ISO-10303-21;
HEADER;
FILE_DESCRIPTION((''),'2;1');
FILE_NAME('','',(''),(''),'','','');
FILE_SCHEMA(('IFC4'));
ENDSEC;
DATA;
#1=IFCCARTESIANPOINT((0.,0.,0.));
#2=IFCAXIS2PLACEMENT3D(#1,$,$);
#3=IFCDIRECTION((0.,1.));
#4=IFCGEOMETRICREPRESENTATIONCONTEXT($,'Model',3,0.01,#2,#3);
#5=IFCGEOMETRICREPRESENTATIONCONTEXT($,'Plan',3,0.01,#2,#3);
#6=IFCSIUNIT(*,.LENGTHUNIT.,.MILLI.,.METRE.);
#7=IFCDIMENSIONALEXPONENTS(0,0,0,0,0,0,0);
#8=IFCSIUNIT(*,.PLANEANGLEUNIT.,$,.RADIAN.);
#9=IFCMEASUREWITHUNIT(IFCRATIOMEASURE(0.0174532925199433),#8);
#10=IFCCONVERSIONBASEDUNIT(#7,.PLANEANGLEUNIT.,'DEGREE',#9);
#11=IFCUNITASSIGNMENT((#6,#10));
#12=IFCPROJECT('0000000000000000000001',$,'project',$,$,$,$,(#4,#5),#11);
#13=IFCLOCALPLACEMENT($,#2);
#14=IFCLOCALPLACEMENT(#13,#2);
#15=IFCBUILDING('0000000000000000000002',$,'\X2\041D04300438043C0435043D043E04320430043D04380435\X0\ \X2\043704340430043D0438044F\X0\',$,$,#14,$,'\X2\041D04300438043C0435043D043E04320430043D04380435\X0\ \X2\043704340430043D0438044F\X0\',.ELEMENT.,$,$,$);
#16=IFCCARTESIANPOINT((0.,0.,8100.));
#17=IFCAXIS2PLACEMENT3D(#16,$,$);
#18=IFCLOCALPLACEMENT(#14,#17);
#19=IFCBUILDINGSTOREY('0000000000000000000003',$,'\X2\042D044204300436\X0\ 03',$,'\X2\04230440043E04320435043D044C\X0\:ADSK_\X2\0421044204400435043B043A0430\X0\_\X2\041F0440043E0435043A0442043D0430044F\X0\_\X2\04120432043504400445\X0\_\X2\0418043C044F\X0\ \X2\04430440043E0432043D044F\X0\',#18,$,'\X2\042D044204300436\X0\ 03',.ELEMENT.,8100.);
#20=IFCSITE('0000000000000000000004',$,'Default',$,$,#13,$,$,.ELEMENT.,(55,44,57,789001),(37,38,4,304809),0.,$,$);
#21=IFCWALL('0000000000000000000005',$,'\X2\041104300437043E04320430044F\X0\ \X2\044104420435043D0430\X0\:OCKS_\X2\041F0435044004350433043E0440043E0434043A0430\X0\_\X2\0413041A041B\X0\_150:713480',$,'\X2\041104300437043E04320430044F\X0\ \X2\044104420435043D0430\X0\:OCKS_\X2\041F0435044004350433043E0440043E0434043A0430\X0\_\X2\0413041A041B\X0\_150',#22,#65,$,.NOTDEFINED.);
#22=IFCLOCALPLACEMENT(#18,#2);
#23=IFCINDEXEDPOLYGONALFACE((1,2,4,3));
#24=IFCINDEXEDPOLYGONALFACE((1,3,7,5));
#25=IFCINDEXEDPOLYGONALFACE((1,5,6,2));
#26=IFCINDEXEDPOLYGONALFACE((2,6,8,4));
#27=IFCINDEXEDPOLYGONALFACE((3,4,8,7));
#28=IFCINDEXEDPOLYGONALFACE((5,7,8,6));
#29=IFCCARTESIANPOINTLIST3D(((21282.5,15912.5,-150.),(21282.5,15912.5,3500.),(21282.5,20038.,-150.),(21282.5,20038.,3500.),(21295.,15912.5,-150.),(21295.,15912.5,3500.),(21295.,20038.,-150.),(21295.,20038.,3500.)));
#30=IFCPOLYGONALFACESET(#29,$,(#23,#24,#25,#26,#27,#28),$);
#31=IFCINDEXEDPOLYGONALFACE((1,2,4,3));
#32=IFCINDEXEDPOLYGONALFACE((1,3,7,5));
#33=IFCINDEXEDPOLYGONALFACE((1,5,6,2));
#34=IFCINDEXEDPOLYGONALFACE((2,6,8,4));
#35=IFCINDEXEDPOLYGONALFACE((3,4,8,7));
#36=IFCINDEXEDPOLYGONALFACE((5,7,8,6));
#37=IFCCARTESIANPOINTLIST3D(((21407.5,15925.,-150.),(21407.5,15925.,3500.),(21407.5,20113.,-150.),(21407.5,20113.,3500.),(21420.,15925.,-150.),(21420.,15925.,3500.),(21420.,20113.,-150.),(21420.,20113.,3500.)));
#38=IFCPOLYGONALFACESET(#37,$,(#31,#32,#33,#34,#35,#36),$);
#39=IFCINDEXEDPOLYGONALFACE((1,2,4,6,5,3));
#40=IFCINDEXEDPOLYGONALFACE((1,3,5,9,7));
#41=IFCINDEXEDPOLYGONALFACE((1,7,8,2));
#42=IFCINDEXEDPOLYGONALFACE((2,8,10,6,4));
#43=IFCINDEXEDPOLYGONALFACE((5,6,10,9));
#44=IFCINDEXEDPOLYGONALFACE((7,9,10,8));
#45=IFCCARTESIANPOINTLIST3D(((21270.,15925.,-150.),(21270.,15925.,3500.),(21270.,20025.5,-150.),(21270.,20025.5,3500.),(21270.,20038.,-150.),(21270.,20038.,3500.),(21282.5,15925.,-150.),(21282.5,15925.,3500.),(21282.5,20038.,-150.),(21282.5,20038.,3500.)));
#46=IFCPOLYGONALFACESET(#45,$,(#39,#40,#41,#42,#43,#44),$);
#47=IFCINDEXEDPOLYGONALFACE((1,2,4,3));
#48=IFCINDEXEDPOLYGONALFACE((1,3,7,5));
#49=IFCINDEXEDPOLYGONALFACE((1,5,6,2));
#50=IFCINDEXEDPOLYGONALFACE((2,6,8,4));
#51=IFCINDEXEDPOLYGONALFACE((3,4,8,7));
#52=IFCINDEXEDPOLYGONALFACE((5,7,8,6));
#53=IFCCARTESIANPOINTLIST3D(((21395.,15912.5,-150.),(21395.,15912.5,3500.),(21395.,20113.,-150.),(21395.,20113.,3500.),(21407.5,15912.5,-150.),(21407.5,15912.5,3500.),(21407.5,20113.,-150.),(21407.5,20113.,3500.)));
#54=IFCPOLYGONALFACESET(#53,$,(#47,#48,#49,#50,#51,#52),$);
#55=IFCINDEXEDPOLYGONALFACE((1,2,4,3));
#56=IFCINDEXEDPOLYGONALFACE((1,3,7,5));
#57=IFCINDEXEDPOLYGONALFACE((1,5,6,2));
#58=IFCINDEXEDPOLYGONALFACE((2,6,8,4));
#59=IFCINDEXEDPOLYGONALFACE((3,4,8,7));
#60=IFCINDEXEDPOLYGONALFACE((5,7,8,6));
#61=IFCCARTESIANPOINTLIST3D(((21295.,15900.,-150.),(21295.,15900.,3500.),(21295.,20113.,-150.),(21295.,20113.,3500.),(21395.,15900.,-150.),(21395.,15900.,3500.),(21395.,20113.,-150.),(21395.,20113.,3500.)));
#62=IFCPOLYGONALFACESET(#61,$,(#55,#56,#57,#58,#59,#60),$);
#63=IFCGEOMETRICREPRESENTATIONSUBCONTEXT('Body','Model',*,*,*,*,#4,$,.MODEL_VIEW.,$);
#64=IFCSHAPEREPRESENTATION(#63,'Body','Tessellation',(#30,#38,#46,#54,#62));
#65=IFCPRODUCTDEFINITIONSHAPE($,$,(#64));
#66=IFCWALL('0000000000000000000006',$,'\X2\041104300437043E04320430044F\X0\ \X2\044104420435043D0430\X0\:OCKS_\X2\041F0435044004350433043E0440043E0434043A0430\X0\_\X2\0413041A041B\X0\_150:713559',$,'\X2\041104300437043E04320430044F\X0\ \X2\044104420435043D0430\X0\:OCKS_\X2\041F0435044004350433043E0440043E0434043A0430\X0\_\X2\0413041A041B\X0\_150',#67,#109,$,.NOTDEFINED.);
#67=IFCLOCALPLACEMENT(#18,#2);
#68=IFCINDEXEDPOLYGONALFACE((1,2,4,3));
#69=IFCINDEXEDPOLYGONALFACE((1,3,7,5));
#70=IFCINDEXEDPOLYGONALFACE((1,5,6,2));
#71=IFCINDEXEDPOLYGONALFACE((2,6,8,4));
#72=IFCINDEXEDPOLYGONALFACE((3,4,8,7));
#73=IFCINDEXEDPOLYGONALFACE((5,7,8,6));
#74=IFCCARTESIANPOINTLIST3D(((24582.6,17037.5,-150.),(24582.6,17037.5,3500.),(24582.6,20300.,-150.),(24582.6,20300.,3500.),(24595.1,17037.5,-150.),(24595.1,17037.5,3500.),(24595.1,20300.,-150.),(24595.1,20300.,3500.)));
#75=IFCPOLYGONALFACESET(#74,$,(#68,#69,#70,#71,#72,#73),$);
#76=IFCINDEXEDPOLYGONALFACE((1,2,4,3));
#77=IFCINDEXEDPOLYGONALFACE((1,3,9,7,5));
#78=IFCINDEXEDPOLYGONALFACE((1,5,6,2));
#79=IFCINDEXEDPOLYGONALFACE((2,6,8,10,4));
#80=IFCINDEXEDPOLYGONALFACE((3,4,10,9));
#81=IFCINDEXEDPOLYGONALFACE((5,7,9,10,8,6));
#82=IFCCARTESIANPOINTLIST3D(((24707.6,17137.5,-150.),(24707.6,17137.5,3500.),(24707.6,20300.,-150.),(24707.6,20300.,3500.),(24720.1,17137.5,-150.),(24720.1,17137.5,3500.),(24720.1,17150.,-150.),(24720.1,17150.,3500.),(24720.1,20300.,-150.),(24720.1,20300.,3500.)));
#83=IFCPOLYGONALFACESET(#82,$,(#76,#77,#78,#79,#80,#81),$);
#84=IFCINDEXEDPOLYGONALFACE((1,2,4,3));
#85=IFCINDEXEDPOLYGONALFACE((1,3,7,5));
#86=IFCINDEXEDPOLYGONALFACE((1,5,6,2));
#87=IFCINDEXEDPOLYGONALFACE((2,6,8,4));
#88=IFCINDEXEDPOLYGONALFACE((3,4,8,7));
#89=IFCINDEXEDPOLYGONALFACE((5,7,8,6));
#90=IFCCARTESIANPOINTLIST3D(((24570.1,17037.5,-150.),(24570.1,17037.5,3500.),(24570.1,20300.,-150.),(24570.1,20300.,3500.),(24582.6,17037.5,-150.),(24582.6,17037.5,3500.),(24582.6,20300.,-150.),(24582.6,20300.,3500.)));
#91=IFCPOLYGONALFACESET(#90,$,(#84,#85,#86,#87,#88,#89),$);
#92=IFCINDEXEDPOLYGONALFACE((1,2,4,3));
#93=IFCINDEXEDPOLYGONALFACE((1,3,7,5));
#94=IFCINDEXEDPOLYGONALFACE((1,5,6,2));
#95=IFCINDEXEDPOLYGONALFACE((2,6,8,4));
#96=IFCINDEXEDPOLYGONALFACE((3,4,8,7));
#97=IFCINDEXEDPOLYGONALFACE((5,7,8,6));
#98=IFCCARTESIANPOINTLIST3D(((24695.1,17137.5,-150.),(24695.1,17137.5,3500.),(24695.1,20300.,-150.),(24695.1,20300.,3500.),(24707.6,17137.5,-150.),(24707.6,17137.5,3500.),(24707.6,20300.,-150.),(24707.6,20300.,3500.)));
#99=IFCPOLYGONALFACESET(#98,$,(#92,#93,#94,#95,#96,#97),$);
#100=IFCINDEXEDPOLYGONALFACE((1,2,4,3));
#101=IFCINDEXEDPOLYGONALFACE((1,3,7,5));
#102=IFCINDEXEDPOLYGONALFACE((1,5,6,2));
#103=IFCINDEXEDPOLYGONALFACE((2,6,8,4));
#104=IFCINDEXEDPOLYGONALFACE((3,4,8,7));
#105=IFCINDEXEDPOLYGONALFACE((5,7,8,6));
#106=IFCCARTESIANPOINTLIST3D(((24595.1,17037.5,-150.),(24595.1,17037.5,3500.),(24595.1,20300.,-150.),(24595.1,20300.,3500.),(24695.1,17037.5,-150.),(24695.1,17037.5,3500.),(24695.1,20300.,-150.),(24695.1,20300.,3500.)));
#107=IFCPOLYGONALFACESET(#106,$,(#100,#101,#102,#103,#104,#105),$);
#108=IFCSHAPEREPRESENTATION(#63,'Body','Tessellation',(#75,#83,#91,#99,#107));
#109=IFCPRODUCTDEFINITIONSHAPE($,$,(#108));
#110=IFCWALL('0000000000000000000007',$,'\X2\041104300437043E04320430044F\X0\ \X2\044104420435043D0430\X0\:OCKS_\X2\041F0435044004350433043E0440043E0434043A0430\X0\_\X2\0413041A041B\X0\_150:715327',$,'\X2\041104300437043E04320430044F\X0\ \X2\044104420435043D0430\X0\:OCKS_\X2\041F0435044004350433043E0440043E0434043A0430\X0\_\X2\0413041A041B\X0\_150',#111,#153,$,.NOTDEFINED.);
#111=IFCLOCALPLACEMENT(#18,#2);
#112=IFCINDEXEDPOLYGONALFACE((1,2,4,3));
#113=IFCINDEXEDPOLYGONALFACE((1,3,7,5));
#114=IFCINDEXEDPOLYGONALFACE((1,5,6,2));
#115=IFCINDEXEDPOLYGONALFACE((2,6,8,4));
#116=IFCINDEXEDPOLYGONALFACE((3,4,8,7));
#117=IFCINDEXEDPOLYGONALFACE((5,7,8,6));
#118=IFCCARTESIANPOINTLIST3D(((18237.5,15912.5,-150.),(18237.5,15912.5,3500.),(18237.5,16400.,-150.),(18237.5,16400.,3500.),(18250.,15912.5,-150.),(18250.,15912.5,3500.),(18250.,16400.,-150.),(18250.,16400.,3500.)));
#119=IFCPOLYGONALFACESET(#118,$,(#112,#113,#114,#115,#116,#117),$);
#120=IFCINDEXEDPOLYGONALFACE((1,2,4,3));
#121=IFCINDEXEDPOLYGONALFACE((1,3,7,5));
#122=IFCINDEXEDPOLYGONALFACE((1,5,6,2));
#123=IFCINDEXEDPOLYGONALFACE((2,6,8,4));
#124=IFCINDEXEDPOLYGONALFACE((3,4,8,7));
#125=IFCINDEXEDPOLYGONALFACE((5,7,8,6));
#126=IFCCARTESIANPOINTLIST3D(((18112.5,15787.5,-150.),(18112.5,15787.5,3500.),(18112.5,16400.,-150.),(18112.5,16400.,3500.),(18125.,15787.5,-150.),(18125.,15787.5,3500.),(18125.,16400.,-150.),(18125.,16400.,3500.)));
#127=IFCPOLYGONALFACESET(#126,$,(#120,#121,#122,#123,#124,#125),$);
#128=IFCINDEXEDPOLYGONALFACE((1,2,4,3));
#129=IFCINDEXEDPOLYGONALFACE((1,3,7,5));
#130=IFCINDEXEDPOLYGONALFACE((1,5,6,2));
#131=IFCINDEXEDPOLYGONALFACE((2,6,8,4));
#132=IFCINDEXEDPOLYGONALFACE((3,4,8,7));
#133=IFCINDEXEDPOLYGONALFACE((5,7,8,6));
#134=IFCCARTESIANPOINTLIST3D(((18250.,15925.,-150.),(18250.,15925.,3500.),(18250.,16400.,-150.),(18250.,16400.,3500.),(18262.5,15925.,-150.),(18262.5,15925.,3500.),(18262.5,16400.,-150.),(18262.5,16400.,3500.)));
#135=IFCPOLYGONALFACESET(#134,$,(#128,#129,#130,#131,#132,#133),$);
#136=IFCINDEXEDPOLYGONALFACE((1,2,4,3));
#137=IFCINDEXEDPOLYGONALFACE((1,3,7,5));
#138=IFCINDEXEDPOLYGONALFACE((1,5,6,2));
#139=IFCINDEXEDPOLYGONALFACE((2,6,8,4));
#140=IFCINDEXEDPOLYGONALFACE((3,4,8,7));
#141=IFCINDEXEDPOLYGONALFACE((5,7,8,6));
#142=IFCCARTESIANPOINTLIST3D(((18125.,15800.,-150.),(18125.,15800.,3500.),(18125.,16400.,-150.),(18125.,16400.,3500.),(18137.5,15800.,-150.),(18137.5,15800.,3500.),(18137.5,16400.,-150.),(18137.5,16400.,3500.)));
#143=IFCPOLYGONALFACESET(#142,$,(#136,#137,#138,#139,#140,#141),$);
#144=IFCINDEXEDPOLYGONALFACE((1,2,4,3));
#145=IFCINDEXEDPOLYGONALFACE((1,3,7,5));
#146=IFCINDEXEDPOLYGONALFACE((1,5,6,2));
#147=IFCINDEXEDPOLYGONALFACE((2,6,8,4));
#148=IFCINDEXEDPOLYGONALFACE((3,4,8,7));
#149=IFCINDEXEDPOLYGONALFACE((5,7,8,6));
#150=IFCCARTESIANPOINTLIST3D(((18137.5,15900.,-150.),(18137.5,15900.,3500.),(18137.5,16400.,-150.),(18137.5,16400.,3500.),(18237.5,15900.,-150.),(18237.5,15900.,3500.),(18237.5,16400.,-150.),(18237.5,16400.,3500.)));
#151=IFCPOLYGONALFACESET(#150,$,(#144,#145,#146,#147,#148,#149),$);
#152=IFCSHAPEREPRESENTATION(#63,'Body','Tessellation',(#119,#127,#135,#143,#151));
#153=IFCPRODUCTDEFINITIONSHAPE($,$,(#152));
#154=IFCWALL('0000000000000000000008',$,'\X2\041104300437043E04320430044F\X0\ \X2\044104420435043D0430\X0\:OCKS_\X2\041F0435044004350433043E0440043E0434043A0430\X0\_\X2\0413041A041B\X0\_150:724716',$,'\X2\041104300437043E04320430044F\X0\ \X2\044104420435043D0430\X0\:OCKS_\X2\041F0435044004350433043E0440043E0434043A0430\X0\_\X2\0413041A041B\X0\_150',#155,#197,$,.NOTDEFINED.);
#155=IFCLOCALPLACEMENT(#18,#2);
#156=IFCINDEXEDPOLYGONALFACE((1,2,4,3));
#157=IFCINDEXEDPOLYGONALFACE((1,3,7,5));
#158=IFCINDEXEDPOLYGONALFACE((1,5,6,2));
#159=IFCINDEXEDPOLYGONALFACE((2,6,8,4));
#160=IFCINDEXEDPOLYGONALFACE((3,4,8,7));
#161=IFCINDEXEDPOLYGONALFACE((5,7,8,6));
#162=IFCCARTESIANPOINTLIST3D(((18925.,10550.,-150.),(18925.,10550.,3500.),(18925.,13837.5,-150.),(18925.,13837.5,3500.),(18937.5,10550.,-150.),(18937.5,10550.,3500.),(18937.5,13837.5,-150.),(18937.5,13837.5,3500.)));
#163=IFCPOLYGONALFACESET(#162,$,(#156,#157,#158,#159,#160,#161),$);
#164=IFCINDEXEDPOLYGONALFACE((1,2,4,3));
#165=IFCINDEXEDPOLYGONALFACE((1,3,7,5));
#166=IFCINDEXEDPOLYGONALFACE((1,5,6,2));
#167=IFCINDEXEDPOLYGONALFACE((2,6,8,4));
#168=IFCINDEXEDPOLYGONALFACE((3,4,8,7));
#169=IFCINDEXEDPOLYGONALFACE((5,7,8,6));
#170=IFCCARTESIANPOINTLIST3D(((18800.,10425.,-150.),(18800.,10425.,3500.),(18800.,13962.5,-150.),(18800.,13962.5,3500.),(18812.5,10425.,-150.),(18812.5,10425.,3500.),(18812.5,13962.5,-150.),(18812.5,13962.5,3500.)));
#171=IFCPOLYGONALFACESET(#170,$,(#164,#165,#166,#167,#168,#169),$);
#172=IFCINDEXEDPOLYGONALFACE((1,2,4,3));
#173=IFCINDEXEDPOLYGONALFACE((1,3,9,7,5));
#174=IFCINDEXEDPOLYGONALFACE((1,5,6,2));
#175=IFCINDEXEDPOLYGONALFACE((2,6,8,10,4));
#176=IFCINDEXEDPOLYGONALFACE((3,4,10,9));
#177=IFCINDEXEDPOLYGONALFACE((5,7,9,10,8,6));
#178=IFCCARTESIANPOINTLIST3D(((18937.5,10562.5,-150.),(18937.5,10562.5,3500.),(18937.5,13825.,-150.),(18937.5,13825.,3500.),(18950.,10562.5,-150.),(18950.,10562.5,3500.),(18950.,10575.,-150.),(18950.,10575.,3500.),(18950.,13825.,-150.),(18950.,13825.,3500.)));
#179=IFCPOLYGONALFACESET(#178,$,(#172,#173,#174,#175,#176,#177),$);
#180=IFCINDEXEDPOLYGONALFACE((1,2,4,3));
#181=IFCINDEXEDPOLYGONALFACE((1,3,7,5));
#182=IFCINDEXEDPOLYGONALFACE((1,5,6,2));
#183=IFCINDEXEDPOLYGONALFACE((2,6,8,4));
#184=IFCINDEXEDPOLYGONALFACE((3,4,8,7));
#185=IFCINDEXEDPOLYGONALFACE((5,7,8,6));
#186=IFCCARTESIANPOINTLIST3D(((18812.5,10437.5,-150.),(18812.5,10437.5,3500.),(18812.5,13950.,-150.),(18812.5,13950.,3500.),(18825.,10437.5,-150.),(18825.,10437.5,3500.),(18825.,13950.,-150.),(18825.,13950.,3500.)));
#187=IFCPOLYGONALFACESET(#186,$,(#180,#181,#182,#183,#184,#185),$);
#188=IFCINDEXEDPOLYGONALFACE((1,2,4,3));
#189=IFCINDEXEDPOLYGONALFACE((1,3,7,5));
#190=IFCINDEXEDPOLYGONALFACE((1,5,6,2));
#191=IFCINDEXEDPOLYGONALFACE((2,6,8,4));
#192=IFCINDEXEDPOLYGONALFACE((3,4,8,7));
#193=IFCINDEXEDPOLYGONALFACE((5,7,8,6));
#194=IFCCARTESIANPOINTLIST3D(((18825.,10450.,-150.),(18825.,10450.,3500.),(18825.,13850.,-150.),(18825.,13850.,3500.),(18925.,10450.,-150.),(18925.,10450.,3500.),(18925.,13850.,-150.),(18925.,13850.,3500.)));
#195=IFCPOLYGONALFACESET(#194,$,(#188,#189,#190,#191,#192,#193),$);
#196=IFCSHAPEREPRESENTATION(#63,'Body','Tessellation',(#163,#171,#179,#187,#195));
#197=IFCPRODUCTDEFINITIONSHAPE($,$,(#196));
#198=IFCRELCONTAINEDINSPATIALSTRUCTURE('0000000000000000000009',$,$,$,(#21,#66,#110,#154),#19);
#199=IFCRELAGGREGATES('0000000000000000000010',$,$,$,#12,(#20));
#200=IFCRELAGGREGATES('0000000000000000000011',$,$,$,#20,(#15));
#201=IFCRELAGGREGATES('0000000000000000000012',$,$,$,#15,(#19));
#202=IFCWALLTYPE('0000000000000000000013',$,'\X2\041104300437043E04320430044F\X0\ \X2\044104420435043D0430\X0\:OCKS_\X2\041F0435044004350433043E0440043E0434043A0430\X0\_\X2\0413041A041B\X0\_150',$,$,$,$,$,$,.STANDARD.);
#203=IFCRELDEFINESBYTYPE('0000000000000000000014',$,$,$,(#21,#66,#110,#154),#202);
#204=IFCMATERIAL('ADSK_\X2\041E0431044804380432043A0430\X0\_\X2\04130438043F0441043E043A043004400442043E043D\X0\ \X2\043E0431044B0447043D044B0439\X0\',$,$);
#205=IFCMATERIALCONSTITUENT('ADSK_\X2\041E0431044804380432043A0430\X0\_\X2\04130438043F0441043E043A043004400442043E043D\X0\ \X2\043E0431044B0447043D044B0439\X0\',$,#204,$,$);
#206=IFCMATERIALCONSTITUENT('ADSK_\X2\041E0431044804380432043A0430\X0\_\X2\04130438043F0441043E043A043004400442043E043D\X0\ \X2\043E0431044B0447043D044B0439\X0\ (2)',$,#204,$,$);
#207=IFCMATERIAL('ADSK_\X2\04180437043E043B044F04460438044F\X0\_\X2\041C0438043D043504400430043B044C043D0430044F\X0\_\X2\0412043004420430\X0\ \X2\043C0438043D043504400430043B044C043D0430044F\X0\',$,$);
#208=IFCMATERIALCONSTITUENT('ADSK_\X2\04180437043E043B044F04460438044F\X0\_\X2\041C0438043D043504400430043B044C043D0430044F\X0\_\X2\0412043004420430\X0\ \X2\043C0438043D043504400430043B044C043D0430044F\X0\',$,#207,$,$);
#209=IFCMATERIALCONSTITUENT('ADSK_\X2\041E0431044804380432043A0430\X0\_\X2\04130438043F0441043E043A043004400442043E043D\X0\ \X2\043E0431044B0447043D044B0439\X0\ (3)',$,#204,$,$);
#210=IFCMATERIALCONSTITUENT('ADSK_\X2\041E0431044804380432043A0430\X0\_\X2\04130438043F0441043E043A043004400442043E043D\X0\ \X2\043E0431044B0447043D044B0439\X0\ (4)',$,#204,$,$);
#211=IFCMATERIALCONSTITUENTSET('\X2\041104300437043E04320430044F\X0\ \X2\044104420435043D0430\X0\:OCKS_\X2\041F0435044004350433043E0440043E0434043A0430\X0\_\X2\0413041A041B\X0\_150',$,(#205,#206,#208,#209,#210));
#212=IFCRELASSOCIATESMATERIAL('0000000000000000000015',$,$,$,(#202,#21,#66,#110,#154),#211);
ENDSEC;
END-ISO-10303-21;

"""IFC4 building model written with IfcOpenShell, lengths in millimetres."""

from ifc_helpers import new_model, entity, si_unit, converted_unit, direction, frame, origin, place, context, subcontext, project, spatial, indexed_curve, outline, extrude, material, constituent, constituent_set, type_object, element, save


model = new_model("IFC4")

# Units and contexts
model_context = context("Model", 3, precision=0.01, world=origin(), true_north=direction((0.0, 1.0)))
plan_context = context("Plan", 3, precision=0.01, world=origin(), true_north=direction((0.0, 1.0)))
body_context = subcontext(model_context, "Body", "Model", "MODEL_VIEW")
ifc_project = project(units=[si_unit("LENGTHUNIT", "METRE", prefix="MILLI"), converted_unit("PLANEANGLEUNIT", "DEGREE", entity("IfcRatioMeasure", 0.0174532925199433), si_unit("PLANEANGLEUNIT", "RADIAN"), dimensions=[0, 0, 0, 0, 0, 0, 0])], contexts=[model_context, plan_context])

# Site, building, storey
site_placement = place(None, frame((0.0, 0.0, 0.0)))
site = spatial("IfcSite", under=ifc_project, at=site_placement, Name="Default", CompositionType="ELEMENT", RefLatitude=(55, 44, 57, 789001), RefLongitude=(37, 38, 4, 304809), RefElevation=0.0)
building_placement = place(site_placement, origin())
building = spatial("IfcBuilding", under=site, at=building_placement, Name="Наименование здания", LongName="Наименование здания", CompositionType="ELEMENT")
storey_placement = place(building_placement, frame((0.0, 0.0, 8100.0)))
storey = spatial("IfcBuildingStorey", under=building, at=storey_placement, Name="Этаж 03", ObjectType="Уровень:ADSK_Стрелка_Проектная_Вверх_Имя уровня", LongName="Этаж 03", CompositionType="ELEMENT", Elevation=8100.0)

# Walls
ifc_material_1 = material(Name="ADSK_Обшивка_Гипсокартон обычный")
ifc_constituent_1 = constituent(ifc_material_1, Name="ADSK_Обшивка_Гипсокартон обычный")
ifc_constituent_2 = constituent(ifc_material_1, Name="ADSK_Обшивка_Гипсокартон обычный (2)")
ifc_material_2 = material(Name="ADSK_Изоляция_Минеральная_Вата минеральная")
ifc_constituent_3 = constituent(ifc_material_2, Name="ADSK_Изоляция_Минеральная_Вата минеральная")
ifc_constituent_4 = constituent(ifc_material_1, Name="ADSK_Обшивка_Гипсокартон обычный (3)")
ifc_constituent_5 = constituent(ifc_material_1, Name="ADSK_Обшивка_Гипсокартон обычный (4)")
ifc_constituent_set_1 = constituent_set(constituents=[ifc_constituent_1, ifc_constituent_2, ifc_constituent_3, ifc_constituent_4, ifc_constituent_5], Name="Базовая стена:OCKS_Перегородка_ГКЛ_150")
wall_type_1 = type_object("IfcWallType", Name="Базовая стена:OCKS_Перегородка_ГКЛ_150", PredefinedType="STANDARD", material=ifc_constituent_set_1)
wall_1_placement = place(storey_placement, frame((21345.0, 15925.0, -150.0), z_axis=(0.0, 0.0, 1.0), x_axis=(0.0, 1.0, 0.0)))
element("IfcWall", 1, at=wall_1_placement, inside=storey, type_object=wall_type_1, material=ifc_constituent_set_1, Name="Базовая стена:OCKS_Перегородка_ГКЛ_150:713480", ObjectType="Базовая стена:OCKS_Перегородка_ГКЛ_150", PredefinedType="NOTDEFINED", context=body_context, shape_type="SweptSolid", body=[
    extrude(outline(indexed_curve([(-2062.8, -6.2), (2062.8, -6.2), (2062.8, 6.2), (-2062.8, 6.2), (-2062.8, -6.2)], self_intersect=False)), frame((2050.3, 56.2, 0.0)), (0.0, 0.0, 1.0), 3650.0),
    extrude(outline(indexed_curve([(-6.3, -2094.0), (6.2, -2094.0), (6.3, 2094.0), (-6.2, 2094.0), (-6.3, -2094.0)], self_intersect=False)), frame((2094.0, -68.7, 0.0), z_axis=(0.0, 0.0, 1.0), x_axis=(0.0, 1.0, 0.0)), (0.0, 0.0, 1.0), 3650.0),
    extrude(outline(indexed_curve([(-1635.2, -5.0), (2465.3, -5.0), (2465.3, 7.5), (-1647.7, 7.5), (-1647.7, -5.0), (-1635.2, -5.0)], self_intersect=False)), frame((2465.3, 70.0, 0.0), z_axis=(0.0, 0.0, 1.0), x_axis=(-1.0, 0.0, 0.0)), (0.0, 0.0, 1.0), 3650.0),
    extrude(outline(indexed_curve([(-2100.3, -6.2), (2100.3, -6.2), (2100.3, 6.2), (-2100.3, 6.2), (-2100.3, -6.2)], self_intersect=False)), frame((2087.8, -56.3, 0.0)), (0.0, 0.0, 1.0), 3650.0),
    extrude(outline(indexed_curve([(-2106.5, -50.0), (2106.5, -50.0), (2106.5, 50.0), (-2106.5, 50.0), (-2106.5, -50.0)], self_intersect=False)), frame((2081.5, 0.0, 0.0)), (0.0, 0.0, 1.0), 3650.0),
])
wall_2_placement = place(storey_placement, frame((24645.1, 20300.0, -150.0), z_axis=(0.0, 0.0, 1.0), x_axis=(0.0, -1.0, 0.0)))
element("IfcWall", 2, at=wall_2_placement, inside=storey, type_object=wall_type_1, material=ifc_constituent_set_1, Name="Базовая стена:OCKS_Перегородка_ГКЛ_150:713559", ObjectType="Базовая стена:OCKS_Перегородка_ГКЛ_150", PredefinedType="NOTDEFINED", context=body_context, shape_type="SweptSolid", body=[
    extrude(outline(indexed_curve([(-1631.3, -6.2), (1631.3, -6.2), (1631.3, 6.3), (-1631.3, 6.3), (-1631.3, -6.2)], self_intersect=False)), frame((1631.3, -56.3, 0.0)), (0.0, 0.0, 1.0), 3650.0),
    extrude(outline(indexed_curve([(-1255.0, -5.0), (1895.0, -5.0), (1895.0, 7.5), (-1267.5, 7.5), (-1267.5, -5.0), (-1255.0, -5.0)], self_intersect=False)), frame((1895.0, 70.0, 0.0), z_axis=(0.0, 0.0, 1.0), x_axis=(-1.0, 0.0, 0.0)), (0.0, 0.0, 1.0), 3650.0),
    extrude(outline(indexed_curve([(-6.3, -1631.3), (6.2, -1631.3), (6.3, 1631.3), (-6.2, 1631.3), (-6.3, -1631.3)], self_intersect=False)), frame((1631.3, -68.7, 0.0), z_axis=(0.0, 0.0, 1.0), x_axis=(0.0, 1.0, 0.0)), (0.0, 0.0, 1.0), 3650.0),
    extrude(outline(indexed_curve([(-1581.3, -6.2), (1581.3, -6.2), (1581.3, 6.3), (-1581.3, 6.3), (-1581.3, -6.2)], self_intersect=False)), frame((1581.3, 56.2, 0.0)), (0.0, 0.0, 1.0), 3650.0),
    extrude(outline(indexed_curve([(-1631.3, -50.0), (1631.3, -50.0), (1631.3, 50.0), (-1631.3, 50.0), (-1631.3, -50.0)], self_intersect=False)), frame((1631.3, 0.0, 0.0)), (0.0, 0.0, 1.0), 3650.0),
])

# Wall
wall_3_placement = place(storey_placement, frame((18187.5, 15925.0, -150.0), z_axis=(0.0, 0.0, 1.0), x_axis=(0.0, 1.0, 0.0)))
element("IfcWall", 3, at=wall_3_placement, inside=storey, type_object=wall_type_1, material=ifc_constituent_set_1, Name="Базовая стена:OCKS_Перегородка_ГКЛ_150:715327", ObjectType="Базовая стена:OCKS_Перегородка_ГКЛ_150", PredefinedType="NOTDEFINED", context=body_context, shape_type="SweptSolid", body=[
    extrude(outline(indexed_curve([(-243.8, -6.3), (243.8, -6.3), (243.8, 6.3), (-243.8, 6.3), (-243.8, -6.3)], self_intersect=False)), frame((231.3, -56.3, 0.0)), (0.0, 0.0, 1.0), 3650.0),
    extrude(outline(indexed_curve([(-6.3, -306.3), (6.2, -306.3), (6.2, 306.3), (-6.3, 306.3), (-6.3, -306.3)], self_intersect=False)), frame((168.8, 68.7, 0.0), z_axis=(0.0, 0.0, 1.0), x_axis=(0.0, -1.0, 0.0)), (0.0, 0.0, 1.0), 3650.0),
    extrude(outline(indexed_curve([(-6.3, -237.5), (6.2, -237.5), (6.2, 237.5), (-6.3, 237.5), (-6.3, -237.5)], self_intersect=False)), frame((237.5, -68.7, 0.0), z_axis=(0.0, 0.0, 1.0), x_axis=(0.0, 1.0, 0.0)), (0.0, 0.0, 1.0), 3650.0),
    extrude(outline(indexed_curve([(-300.0, -6.3), (300.0, -6.3), (300.0, 6.3), (-300.0, 6.3), (-300.0, -6.3)], self_intersect=False)), frame((175.0, 56.3, 0.0)), (0.0, 0.0, 1.0), 3650.0),
    extrude(outline(indexed_curve([(-250.0, -50.0), (250.0, -50.0), (250.0, 50.0), (-250.0, 50.0), (-250.0, -50.0)], self_intersect=False)), frame((225.0, 0.0, 0.0)), (0.0, 0.0, 1.0), 3650.0),
])

# Wall
wall_4_placement = place(storey_placement, frame((18875.0, 13825.0, -150.0), z_axis=(0.0, 0.0, 1.0), x_axis=(0.0, -1.0, 0.0)))
element("IfcWall", 4, at=wall_4_placement, inside=storey, type_object=wall_type_1, material=ifc_constituent_set_1, Name="Базовая стена:OCKS_Перегородка_ГКЛ_150:724716", ObjectType="Базовая стена:OCKS_Перегородка_ГКЛ_150", PredefinedType="NOTDEFINED", context=body_context, shape_type="SweptSolid", body=[
    extrude(outline(indexed_curve([(-1643.8, -6.3), (1643.8, -6.3), (1643.8, 6.2), (-1643.8, 6.2), (-1643.8, -6.3)], self_intersect=False)), frame((1631.3, 56.3, 0.0)), (0.0, 0.0, 1.0), 3650.0),
    extrude(outline(indexed_curve([(-6.3, -1768.8), (6.2, -1768.8), (6.3, 1768.8), (-6.2, 1768.8), (-6.3, -1768.8)], self_intersect=False)), frame((1631.3, -68.8, 0.0), z_axis=(0.0, 0.0, 1.0), x_axis=(0.0, 1.0, 0.0)), (0.0, 0.0, 1.0), 3650.0),
    extrude(outline(indexed_curve([(-1295.0, -5.0), (1955.0, -5.0), (1955.0, 7.5), (-1307.5, 7.5), (-1307.5, -5.0), (-1295.0, -5.0)], self_intersect=False)), frame((1955.0, 70.0, 0.0), z_axis=(0.0, 0.0, 1.0), x_axis=(-1.0, 0.0, 0.0)), (0.0, 0.0, 1.0), 3650.0),
    extrude(outline(indexed_curve([(-1756.3, -6.3), (1756.3, -6.3), (1756.3, 6.2), (-1756.3, 6.2), (-1756.3, -6.3)], self_intersect=False)), frame((1631.3, -56.2, 0.0)), (0.0, 0.0, 1.0), 3650.0),
    extrude(outline(indexed_curve([(-1700.0, -50.0), (1700.0, -50.0), (1700.0, 50.0), (-1700.0, 50.0), (-1700.0, -50.0)], self_intersect=False)), frame((1675.0, 0.0, 0.0)), (0.0, 0.0, 1.0), 3650.0),
])

save(model, "model.ifc")
